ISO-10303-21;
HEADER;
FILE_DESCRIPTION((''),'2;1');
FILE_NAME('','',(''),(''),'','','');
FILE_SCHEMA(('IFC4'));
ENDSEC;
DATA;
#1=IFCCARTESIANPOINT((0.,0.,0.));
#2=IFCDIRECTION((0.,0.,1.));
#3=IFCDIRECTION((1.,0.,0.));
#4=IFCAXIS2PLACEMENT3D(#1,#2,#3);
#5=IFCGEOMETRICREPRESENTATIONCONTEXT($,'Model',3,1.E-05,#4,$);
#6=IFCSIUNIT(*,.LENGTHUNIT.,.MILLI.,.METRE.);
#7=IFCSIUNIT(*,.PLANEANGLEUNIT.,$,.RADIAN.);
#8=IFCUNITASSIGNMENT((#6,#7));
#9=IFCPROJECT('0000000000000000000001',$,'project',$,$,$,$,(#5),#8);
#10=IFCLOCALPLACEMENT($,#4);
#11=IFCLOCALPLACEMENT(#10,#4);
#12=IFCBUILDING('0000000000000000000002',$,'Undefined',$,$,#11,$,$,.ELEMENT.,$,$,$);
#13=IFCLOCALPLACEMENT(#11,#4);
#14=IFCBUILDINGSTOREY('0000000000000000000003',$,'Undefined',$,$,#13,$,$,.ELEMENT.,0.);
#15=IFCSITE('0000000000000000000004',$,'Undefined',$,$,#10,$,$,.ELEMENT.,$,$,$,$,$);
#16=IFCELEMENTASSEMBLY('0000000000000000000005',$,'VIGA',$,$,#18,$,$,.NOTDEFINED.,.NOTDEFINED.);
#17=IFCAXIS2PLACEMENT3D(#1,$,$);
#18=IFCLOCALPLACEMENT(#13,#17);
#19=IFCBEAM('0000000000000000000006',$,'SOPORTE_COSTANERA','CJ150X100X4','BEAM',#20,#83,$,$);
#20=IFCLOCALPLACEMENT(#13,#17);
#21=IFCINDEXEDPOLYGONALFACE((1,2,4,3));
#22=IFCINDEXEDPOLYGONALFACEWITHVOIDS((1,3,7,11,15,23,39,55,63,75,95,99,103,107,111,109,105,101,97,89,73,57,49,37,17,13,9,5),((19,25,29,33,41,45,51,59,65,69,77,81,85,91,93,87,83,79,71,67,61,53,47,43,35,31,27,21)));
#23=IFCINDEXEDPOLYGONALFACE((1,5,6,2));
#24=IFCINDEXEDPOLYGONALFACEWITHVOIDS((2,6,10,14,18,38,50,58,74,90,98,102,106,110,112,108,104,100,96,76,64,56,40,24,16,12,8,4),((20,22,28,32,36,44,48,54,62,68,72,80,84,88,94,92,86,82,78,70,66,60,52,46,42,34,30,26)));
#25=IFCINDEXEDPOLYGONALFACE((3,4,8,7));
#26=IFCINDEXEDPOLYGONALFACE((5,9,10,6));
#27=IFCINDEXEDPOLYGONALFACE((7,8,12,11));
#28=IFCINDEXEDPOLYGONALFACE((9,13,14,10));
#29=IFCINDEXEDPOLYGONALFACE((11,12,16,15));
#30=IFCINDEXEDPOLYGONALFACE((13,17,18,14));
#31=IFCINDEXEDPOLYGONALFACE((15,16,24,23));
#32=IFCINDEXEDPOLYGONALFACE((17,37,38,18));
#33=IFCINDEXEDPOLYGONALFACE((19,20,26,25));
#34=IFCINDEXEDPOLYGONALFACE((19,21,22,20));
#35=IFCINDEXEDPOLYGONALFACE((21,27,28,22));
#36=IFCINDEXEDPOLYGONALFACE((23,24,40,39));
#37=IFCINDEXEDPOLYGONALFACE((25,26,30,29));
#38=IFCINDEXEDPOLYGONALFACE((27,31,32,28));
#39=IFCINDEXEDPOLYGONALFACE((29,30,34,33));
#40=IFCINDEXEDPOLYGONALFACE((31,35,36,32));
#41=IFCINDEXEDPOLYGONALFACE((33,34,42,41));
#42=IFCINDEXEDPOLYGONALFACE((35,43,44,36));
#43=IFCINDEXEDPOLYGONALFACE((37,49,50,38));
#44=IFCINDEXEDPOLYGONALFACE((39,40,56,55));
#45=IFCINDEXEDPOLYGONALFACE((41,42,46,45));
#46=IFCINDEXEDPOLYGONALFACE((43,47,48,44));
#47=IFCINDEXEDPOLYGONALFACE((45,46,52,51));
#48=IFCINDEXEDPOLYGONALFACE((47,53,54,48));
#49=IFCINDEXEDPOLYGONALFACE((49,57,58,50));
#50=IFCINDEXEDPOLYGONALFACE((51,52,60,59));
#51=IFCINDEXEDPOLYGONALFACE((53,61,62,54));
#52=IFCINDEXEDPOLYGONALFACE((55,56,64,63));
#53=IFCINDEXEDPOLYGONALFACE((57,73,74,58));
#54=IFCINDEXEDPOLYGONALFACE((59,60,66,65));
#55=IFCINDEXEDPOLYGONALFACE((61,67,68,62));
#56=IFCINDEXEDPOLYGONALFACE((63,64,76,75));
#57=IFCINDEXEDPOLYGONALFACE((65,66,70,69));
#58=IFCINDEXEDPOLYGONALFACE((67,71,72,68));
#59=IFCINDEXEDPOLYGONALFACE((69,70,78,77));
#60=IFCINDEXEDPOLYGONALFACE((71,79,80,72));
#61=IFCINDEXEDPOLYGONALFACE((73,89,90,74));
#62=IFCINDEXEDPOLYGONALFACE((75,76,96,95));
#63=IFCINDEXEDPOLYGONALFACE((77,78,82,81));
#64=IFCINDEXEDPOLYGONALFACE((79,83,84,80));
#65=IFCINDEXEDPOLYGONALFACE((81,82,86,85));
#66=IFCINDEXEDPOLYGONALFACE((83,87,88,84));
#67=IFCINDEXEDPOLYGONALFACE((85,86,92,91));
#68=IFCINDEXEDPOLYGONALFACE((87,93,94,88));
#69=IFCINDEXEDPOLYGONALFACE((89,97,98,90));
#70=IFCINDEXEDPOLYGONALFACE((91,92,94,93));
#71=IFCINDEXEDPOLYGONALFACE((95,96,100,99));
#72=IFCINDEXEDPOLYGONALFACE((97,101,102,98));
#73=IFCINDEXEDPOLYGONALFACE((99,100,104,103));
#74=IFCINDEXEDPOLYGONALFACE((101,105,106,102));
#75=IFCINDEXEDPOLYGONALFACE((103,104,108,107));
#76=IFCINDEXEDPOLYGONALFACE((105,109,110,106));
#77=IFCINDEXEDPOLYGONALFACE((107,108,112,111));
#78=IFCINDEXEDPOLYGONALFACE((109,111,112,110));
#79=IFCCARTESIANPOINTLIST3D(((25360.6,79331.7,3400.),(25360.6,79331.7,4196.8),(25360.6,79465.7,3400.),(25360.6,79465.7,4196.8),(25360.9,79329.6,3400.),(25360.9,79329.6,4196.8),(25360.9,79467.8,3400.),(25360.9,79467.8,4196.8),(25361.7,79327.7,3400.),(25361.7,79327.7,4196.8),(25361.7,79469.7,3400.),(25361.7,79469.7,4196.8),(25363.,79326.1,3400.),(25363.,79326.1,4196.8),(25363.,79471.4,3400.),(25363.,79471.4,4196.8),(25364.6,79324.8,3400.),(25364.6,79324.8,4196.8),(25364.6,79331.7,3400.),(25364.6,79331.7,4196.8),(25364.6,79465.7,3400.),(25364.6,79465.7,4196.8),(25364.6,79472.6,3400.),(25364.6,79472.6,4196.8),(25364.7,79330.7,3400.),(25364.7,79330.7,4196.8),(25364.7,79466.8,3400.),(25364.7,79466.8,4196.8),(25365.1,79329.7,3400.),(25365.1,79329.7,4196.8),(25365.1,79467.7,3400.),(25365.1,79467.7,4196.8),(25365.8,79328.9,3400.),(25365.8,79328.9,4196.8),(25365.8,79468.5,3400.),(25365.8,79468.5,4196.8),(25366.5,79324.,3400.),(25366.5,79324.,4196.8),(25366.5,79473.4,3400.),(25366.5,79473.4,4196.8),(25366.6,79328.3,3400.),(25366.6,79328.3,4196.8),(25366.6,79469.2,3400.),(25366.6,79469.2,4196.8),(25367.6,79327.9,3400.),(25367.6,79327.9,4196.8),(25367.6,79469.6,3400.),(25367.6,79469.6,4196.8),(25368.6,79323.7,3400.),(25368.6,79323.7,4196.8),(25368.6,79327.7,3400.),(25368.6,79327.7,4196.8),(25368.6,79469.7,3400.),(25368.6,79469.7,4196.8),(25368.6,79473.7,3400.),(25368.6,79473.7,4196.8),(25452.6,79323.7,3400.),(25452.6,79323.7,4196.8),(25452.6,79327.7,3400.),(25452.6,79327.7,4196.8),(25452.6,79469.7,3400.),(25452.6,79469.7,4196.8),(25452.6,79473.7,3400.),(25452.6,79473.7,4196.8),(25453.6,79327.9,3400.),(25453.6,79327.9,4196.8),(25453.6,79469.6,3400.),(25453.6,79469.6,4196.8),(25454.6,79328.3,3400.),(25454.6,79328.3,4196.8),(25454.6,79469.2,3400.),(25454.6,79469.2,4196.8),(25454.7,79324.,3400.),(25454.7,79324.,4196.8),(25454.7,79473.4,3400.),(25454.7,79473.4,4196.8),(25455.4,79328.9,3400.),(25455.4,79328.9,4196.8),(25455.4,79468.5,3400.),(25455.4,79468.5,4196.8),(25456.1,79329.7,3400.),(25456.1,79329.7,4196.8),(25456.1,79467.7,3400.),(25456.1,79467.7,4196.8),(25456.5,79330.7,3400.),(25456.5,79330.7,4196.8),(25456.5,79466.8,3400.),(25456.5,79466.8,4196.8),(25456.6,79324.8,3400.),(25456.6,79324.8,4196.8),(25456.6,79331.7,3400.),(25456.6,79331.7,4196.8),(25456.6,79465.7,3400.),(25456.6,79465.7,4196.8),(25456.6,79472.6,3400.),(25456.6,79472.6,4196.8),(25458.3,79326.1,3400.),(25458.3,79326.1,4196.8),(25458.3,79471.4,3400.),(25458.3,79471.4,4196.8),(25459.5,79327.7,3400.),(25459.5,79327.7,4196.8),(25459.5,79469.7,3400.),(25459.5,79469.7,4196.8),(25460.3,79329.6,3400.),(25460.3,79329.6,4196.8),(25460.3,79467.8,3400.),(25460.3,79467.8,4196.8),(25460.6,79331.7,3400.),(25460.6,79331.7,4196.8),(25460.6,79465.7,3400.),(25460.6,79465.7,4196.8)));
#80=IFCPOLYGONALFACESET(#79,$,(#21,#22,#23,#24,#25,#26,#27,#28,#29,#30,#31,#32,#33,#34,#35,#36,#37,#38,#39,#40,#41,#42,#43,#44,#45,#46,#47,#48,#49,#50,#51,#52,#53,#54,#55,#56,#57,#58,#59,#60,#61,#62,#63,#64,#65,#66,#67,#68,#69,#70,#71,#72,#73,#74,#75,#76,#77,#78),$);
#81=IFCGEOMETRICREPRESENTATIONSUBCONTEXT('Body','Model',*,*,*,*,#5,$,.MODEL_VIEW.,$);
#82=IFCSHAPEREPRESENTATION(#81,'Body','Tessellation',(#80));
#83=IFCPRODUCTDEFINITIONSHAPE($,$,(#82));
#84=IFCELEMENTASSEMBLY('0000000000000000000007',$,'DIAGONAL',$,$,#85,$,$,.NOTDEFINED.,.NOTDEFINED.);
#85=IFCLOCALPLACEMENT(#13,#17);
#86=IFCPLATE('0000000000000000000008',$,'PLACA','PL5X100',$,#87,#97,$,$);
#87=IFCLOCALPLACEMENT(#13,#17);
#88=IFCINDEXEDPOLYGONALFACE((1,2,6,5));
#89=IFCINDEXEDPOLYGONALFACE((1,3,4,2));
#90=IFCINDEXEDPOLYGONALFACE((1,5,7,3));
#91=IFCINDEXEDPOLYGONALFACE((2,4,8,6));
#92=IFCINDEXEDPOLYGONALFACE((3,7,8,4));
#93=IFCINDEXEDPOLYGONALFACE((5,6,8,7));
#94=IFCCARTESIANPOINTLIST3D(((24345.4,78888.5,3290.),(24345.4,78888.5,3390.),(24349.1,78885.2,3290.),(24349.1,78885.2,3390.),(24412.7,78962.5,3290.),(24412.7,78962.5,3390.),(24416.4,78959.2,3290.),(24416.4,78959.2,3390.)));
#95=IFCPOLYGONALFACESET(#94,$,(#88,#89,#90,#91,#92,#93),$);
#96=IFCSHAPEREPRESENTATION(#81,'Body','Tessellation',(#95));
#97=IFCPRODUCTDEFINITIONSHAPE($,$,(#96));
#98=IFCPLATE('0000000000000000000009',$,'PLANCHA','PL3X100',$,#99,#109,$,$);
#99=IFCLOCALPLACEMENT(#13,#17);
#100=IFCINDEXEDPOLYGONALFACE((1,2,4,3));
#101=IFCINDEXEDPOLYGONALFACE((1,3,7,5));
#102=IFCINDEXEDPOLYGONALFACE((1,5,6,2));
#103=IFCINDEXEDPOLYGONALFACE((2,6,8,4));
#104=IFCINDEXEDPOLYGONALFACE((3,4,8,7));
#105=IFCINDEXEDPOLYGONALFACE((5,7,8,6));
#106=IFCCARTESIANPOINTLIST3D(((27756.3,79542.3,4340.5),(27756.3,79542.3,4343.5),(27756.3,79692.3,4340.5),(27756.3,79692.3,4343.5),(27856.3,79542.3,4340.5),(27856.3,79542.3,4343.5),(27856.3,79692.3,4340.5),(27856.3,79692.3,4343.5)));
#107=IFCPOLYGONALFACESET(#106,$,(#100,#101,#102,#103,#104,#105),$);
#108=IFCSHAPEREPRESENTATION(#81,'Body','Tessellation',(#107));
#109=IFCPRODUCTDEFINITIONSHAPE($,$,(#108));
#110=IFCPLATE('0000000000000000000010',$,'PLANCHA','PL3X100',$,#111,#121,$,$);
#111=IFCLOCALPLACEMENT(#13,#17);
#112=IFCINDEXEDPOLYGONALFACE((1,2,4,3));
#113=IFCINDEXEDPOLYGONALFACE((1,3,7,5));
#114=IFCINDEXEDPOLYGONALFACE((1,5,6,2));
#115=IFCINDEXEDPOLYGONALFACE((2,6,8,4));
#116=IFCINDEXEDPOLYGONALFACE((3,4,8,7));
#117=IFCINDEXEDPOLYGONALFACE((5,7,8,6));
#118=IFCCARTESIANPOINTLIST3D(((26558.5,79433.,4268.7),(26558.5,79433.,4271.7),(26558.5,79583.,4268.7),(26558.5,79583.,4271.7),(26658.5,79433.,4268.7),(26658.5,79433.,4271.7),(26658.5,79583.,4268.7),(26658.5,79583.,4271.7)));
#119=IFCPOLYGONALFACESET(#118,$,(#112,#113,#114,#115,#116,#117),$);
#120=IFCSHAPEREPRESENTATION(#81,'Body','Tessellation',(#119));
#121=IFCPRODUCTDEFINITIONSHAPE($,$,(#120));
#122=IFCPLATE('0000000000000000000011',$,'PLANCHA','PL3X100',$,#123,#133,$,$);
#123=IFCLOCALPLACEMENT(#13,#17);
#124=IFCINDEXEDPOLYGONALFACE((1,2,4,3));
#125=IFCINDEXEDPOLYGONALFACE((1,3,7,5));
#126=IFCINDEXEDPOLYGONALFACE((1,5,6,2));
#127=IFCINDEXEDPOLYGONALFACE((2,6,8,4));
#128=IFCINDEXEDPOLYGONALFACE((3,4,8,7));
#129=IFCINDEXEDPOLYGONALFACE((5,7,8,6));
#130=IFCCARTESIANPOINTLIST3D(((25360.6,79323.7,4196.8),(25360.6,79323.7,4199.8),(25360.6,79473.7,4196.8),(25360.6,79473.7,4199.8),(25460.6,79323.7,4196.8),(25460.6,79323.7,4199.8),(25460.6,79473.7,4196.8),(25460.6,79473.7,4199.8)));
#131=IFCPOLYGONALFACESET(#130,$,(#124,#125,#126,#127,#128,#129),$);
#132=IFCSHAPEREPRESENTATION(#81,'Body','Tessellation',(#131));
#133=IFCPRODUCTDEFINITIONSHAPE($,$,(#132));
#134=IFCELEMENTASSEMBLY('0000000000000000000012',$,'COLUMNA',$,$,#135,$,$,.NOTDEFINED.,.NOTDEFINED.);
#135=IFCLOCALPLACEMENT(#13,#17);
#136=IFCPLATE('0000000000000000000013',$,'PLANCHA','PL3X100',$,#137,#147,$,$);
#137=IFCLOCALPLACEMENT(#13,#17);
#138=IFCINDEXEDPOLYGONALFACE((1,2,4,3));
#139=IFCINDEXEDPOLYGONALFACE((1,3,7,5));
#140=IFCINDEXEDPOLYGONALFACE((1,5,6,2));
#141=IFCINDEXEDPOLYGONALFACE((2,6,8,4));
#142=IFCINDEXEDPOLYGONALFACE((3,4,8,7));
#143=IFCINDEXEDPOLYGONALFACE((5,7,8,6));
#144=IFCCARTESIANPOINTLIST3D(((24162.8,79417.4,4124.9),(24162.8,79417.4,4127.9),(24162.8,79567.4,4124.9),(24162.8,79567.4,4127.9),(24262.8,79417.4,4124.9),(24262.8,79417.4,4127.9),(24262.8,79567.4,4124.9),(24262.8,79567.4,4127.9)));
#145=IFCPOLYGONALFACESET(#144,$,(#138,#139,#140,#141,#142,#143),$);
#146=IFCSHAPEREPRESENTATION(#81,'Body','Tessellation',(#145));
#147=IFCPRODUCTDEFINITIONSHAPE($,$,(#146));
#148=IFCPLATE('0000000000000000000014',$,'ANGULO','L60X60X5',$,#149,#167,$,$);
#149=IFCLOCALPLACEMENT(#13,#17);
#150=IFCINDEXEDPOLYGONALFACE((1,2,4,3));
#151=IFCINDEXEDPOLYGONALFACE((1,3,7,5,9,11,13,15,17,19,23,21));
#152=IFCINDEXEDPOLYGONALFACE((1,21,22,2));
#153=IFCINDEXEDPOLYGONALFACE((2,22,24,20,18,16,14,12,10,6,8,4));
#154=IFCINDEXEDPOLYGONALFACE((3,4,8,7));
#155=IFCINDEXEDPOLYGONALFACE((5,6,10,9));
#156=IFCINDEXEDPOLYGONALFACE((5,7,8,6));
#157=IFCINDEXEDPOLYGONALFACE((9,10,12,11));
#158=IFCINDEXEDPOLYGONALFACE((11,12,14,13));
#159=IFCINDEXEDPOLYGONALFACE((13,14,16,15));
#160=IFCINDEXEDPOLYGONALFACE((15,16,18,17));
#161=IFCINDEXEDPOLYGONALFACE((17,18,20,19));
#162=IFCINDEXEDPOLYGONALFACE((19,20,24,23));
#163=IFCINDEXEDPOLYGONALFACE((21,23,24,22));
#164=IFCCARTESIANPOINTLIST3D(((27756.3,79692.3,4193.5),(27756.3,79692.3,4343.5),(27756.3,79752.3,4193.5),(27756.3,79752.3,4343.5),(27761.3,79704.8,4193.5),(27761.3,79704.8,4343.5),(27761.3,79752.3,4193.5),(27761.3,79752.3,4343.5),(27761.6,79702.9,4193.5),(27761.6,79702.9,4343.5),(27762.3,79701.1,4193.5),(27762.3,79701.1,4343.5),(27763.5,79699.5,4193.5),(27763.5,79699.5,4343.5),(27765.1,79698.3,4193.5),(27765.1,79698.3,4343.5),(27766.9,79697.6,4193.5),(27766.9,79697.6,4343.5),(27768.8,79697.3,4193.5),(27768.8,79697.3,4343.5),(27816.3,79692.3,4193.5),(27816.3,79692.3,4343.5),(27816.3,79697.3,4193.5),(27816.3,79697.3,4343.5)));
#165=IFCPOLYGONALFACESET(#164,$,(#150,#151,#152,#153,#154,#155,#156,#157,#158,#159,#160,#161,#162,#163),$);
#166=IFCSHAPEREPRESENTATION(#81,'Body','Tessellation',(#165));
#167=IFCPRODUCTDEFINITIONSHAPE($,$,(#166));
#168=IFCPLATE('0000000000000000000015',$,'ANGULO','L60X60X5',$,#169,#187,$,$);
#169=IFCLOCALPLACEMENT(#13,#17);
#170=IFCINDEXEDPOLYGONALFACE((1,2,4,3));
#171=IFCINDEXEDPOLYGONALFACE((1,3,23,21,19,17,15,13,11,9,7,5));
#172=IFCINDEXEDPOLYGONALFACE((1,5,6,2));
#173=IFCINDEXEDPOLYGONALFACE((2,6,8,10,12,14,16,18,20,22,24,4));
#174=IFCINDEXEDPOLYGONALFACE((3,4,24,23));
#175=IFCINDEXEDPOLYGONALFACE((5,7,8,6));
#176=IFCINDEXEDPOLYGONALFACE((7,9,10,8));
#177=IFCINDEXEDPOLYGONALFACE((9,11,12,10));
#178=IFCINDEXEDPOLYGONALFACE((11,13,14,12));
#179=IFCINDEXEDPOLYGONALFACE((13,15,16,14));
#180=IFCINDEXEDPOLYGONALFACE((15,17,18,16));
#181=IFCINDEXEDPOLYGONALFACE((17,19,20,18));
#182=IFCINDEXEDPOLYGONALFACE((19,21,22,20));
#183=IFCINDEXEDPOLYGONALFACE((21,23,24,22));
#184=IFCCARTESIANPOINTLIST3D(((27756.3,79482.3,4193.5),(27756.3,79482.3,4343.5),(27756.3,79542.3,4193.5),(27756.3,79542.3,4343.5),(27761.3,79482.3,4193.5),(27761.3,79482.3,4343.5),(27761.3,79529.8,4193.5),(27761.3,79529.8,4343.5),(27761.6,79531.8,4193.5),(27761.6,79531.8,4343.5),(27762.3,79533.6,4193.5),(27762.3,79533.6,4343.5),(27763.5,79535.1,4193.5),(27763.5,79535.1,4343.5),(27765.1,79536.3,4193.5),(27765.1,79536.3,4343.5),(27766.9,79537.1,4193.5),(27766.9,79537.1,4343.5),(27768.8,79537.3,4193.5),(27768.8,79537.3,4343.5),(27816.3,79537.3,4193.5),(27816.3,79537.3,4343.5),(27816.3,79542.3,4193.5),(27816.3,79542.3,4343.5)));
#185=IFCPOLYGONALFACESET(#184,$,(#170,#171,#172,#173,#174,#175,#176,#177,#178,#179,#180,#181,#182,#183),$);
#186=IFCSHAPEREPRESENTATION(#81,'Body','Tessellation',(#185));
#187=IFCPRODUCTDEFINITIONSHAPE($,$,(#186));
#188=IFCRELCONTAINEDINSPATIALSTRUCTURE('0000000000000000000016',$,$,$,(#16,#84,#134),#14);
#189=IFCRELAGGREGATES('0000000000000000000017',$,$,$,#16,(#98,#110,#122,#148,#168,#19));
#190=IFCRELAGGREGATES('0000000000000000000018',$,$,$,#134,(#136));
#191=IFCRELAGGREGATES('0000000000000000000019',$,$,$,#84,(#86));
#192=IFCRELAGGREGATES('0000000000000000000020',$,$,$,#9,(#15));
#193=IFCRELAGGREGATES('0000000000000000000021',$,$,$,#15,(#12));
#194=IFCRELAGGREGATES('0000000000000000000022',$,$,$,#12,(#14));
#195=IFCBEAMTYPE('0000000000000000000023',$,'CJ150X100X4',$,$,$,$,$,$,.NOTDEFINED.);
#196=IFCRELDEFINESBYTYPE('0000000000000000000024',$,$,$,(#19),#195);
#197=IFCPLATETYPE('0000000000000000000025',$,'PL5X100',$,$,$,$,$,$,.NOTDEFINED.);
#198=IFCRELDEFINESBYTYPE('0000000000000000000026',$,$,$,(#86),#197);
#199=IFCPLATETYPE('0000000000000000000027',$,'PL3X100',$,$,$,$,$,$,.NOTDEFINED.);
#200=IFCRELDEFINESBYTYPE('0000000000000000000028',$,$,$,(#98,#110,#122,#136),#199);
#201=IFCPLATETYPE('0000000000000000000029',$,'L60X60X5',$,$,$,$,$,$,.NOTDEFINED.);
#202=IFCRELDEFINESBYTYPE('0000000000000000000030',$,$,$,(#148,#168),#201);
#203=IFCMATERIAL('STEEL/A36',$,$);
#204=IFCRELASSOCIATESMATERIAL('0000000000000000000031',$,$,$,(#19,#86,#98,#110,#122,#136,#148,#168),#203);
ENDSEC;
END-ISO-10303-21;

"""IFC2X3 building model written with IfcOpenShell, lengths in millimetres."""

from ifc_helpers import new_model, si_unit, frame, origin_with_axes, origin_2d_with_axis, place, context, subcontext, project, spatial, polyline, hollow_rectangle, l_section, outline, extrude, material, type_object, element, aggregate, save


model = new_model("IFC2X3")

# Units and contexts
model_context = context("Model", 3, precision=1e-05, world=origin_with_axes())
body_context = subcontext(model_context, "Body", "Model", "MODEL_VIEW")
ifc_project = project(units=[si_unit("LENGTHUNIT", "METRE", prefix="MILLI"), si_unit("PLANEANGLEUNIT", "RADIAN")], contexts=[model_context])

# Site, building, storey
site_placement = place(None, origin_with_axes())
site = spatial("IfcSite", under=ifc_project, at=site_placement, Name="Undefined", CompositionType="ELEMENT")
building_placement = place(site_placement, origin_with_axes())
building = spatial("IfcBuilding", under=site, at=building_placement, Name="Undefined", CompositionType="ELEMENT")
storey_placement = place(building_placement, origin_with_axes())
storey = spatial("IfcBuildingStorey", under=building, at=storey_placement, Name="Undefined", CompositionType="ELEMENT", Elevation=0.0)

# Shared definitions
ifc_material_1 = material(Name="STEEL/A36")
beam_type = type_object("IfcBeamType", Name="CJ150X100X4", PredefinedType="NOTDEFINED")

# Element assembly, beam
assembly_1_placement = place(storey_placement, origin_with_axes())
assembly_1 = element("IfcElementAssembly", 1, at=assembly_1_placement, inside=storey, Name="VIGA", AssemblyPlace="NOTDEFINED", PredefinedType="NOTDEFINED")
beam_1_placement = place(assembly_1_placement, frame((25410.6, 79398.7, 4196.8), z_axis=(0.0, 1.0, 0.0), x_axis=(0.0, 0.0, -1.0)))
beam_1 = element("IfcBeam", 2, at=beam_1_placement, type_object=beam_type, material=ifc_material_1, Name="SOPORTE_COSTANERA", Description="CJ150X100X4", ObjectType="BEAM", context=body_context, shape_type="SweptSolid", body=[
    extrude(hollow_rectangle(XDim=100.0, YDim=150.0, WallThickness=4.0, InnerFilletRadius=4.0, OuterFilletRadius=8.0, at=origin_2d_with_axis()), frame((796.8, 0.0, 0.0), z_axis=(-1.0, 0.0, 0.0), x_axis=(0.0, -1.0, 0.0)), (0.0, 0.0, 1.0), 796.8),
])

# Element assembly, plate
assembly_2_placement = place(storey_placement, origin_with_axes())
assembly_2 = element("IfcElementAssembly", 3, at=assembly_2_placement, inside=storey, Name="DIAGONAL", AssemblyPlace="NOTDEFINED", PredefinedType="NOTDEFINED")
plate_type_1 = type_object("IfcPlateType", Name="PL5X100", PredefinedType="NOTDEFINED")
plate_1_placement = place(assembly_2_placement, frame((24347.3, 78886.9, 3390.0), z_axis=(0.740066, -0.672535, 0.0), x_axis=(0.0, 0.0, -1.0)))
plate_1 = element("IfcPlate", 4, at=plate_1_placement, type_object=plate_type_1, material=ifc_material_1, Name="PLACA", Description="PL5X100", context=body_context, shape_type="SweptSolid", body=[
    extrude(outline(polyline([(0.0, 0.0), (100.0, 0.0), (100.0, 100.0), (0.0, 100.0), (0.0, 0.0)])), frame((0.0, 0.0, -2.5), z_axis=(0.0, 0.0, 1.0), x_axis=(1.0, 0.0, 0.0)), (0.0, 0.0, 1.0), 5.0),
])

# Plates
plate_type_2 = type_object("IfcPlateType", Name="PL3X100", PredefinedType="NOTDEFINED")
plate_2_placement = place(assembly_1_placement, frame((27856.3, 79542.3, 4342.0), z_axis=(0.0, 0.0, -1.0), x_axis=(-1.0, 0.0, 0.0)))
plate_2 = element("IfcPlate", 5, at=plate_2_placement, type_object=plate_type_2, material=ifc_material_1, Name="PLANCHA", Description="PL3X100", context=body_context, shape_type="SweptSolid", body=[
    extrude(outline(polyline([(0.0, 0.0), (100.0, 0.0), (100.0, 150.0), (0.0, 150.0), (0.0, 0.0)])), frame((0.0, 0.0, -1.5), z_axis=(0.0, 0.0, 1.0), x_axis=(1.0, 0.0, 0.0)), (0.0, 0.0, 1.0), 3.0),
])
plate_3_placement = place(assembly_1_placement, frame((26658.5, 79433.0, 4270.2), z_axis=(0.0, 0.0, -1.0), x_axis=(-1.0, 0.0, 0.0)))
plate_3 = element("IfcPlate", 6, at=plate_3_placement, type_object=plate_type_2, material=ifc_material_1, Name="PLANCHA", Description="PL3X100", context=body_context, shape_type="SweptSolid", body=[
    extrude(outline(polyline([(0.0, 0.0), (100.0, 0.0), (100.0, 150.0), (0.0, 150.0), (0.0, 0.0)])), frame((0.0, 0.0, -1.5), z_axis=(0.0, 0.0, 1.0), x_axis=(1.0, 0.0, 0.0)), (0.0, 0.0, 1.0), 3.0),
])
plate_4_placement = place(assembly_1_placement, frame((25460.6, 79323.7, 4198.3), z_axis=(0.0, 0.0, -1.0), x_axis=(-1.0, 0.0, 0.0)))
plate_4 = element("IfcPlate", 7, at=plate_4_placement, type_object=plate_type_2, material=ifc_material_1, Name="PLANCHA", Description="PL3X100", context=body_context, shape_type="SweptSolid", body=[
    extrude(outline(polyline([(0.0, 0.0), (100.0, 0.0), (100.0, 150.0), (0.0, 150.0), (0.0, 0.0)])), frame((0.0, 0.0, -1.5), z_axis=(0.0, 0.0, 1.0), x_axis=(1.0, 0.0, 0.0)), (0.0, 0.0, 1.0), 3.0),
])

# Element assembly, plate
assembly_3_placement = place(storey_placement, origin_with_axes())
assembly_3 = element("IfcElementAssembly", 8, at=assembly_3_placement, inside=storey, Name="COLUMNA", AssemblyPlace="NOTDEFINED", PredefinedType="NOTDEFINED")
plate_5_placement = place(assembly_3_placement, frame((24262.8, 79417.4, 4126.4), z_axis=(0.0, 0.0, -1.0), x_axis=(-1.0, 0.0, 0.0)))
plate_5 = element("IfcPlate", 9, at=plate_5_placement, type_object=plate_type_2, material=ifc_material_1, Name="PLANCHA", Description="PL3X100", context=body_context, shape_type="SweptSolid", body=[
    extrude(outline(polyline([(0.0, 0.0), (100.0, 0.0), (100.0, 150.0), (0.0, 150.0), (0.0, 0.0)])), frame((0.0, 0.0, -1.5), z_axis=(0.0, 0.0, 1.0), x_axis=(1.0, 0.0, 0.0)), (0.0, 0.0, 1.0), 3.0),
])

# Plates
plate_type_3 = type_object("IfcPlateType", Name="L60X60X5", PredefinedType="NOTDEFINED")
plate_6_placement = place(assembly_1_placement, frame((27786.3, 79722.3, 4193.5), z_axis=(1.0, 0.0, 0.0), x_axis=(0.0, 0.0, 1.0)))
plate_6 = element("IfcPlate", 10, at=plate_6_placement, type_object=plate_type_3, material=ifc_material_1, Name="ANGULO", Description="L60X60X5", context=body_context, shape_type="SweptSolid", body=[
    extrude(l_section(Depth=60.0, Width=60.0, Thickness=5.0, FilletRadius=7.5, at=origin_2d_with_axis()), frame((150.0, 0.0, 0.0), z_axis=(-1.0, 0.0, 0.0), x_axis=(0.0, -1.0, 0.0)), (0.0, 0.0, 1.0), 150.0),
])
plate_7_placement = place(assembly_1_placement, frame((27786.3, 79512.3, 4343.5), z_axis=(1.0, 0.0, 0.0), x_axis=(0.0, 0.0, -1.0)))
plate_7 = element("IfcPlate", 11, at=plate_7_placement, type_object=plate_type_3, material=ifc_material_1, Name="ANGULO", Description="L60X60X5", context=body_context, shape_type="SweptSolid", body=[
    extrude(l_section(Depth=60.0, Width=60.0, Thickness=5.0, FilletRadius=7.5, at=origin_2d_with_axis()), frame((150.0, 0.0, 0.0), z_axis=(-1.0, 0.0, 0.0), x_axis=(0.0, -1.0, 0.0)), (0.0, 0.0, 1.0), 150.0),
])
aggregate(assembly_1, [plate_2, plate_3, plate_4, plate_6, plate_7, beam_1])

aggregate(assembly_3, [plate_5])

aggregate(assembly_2, [plate_1])

save(model, "model.ifc")
